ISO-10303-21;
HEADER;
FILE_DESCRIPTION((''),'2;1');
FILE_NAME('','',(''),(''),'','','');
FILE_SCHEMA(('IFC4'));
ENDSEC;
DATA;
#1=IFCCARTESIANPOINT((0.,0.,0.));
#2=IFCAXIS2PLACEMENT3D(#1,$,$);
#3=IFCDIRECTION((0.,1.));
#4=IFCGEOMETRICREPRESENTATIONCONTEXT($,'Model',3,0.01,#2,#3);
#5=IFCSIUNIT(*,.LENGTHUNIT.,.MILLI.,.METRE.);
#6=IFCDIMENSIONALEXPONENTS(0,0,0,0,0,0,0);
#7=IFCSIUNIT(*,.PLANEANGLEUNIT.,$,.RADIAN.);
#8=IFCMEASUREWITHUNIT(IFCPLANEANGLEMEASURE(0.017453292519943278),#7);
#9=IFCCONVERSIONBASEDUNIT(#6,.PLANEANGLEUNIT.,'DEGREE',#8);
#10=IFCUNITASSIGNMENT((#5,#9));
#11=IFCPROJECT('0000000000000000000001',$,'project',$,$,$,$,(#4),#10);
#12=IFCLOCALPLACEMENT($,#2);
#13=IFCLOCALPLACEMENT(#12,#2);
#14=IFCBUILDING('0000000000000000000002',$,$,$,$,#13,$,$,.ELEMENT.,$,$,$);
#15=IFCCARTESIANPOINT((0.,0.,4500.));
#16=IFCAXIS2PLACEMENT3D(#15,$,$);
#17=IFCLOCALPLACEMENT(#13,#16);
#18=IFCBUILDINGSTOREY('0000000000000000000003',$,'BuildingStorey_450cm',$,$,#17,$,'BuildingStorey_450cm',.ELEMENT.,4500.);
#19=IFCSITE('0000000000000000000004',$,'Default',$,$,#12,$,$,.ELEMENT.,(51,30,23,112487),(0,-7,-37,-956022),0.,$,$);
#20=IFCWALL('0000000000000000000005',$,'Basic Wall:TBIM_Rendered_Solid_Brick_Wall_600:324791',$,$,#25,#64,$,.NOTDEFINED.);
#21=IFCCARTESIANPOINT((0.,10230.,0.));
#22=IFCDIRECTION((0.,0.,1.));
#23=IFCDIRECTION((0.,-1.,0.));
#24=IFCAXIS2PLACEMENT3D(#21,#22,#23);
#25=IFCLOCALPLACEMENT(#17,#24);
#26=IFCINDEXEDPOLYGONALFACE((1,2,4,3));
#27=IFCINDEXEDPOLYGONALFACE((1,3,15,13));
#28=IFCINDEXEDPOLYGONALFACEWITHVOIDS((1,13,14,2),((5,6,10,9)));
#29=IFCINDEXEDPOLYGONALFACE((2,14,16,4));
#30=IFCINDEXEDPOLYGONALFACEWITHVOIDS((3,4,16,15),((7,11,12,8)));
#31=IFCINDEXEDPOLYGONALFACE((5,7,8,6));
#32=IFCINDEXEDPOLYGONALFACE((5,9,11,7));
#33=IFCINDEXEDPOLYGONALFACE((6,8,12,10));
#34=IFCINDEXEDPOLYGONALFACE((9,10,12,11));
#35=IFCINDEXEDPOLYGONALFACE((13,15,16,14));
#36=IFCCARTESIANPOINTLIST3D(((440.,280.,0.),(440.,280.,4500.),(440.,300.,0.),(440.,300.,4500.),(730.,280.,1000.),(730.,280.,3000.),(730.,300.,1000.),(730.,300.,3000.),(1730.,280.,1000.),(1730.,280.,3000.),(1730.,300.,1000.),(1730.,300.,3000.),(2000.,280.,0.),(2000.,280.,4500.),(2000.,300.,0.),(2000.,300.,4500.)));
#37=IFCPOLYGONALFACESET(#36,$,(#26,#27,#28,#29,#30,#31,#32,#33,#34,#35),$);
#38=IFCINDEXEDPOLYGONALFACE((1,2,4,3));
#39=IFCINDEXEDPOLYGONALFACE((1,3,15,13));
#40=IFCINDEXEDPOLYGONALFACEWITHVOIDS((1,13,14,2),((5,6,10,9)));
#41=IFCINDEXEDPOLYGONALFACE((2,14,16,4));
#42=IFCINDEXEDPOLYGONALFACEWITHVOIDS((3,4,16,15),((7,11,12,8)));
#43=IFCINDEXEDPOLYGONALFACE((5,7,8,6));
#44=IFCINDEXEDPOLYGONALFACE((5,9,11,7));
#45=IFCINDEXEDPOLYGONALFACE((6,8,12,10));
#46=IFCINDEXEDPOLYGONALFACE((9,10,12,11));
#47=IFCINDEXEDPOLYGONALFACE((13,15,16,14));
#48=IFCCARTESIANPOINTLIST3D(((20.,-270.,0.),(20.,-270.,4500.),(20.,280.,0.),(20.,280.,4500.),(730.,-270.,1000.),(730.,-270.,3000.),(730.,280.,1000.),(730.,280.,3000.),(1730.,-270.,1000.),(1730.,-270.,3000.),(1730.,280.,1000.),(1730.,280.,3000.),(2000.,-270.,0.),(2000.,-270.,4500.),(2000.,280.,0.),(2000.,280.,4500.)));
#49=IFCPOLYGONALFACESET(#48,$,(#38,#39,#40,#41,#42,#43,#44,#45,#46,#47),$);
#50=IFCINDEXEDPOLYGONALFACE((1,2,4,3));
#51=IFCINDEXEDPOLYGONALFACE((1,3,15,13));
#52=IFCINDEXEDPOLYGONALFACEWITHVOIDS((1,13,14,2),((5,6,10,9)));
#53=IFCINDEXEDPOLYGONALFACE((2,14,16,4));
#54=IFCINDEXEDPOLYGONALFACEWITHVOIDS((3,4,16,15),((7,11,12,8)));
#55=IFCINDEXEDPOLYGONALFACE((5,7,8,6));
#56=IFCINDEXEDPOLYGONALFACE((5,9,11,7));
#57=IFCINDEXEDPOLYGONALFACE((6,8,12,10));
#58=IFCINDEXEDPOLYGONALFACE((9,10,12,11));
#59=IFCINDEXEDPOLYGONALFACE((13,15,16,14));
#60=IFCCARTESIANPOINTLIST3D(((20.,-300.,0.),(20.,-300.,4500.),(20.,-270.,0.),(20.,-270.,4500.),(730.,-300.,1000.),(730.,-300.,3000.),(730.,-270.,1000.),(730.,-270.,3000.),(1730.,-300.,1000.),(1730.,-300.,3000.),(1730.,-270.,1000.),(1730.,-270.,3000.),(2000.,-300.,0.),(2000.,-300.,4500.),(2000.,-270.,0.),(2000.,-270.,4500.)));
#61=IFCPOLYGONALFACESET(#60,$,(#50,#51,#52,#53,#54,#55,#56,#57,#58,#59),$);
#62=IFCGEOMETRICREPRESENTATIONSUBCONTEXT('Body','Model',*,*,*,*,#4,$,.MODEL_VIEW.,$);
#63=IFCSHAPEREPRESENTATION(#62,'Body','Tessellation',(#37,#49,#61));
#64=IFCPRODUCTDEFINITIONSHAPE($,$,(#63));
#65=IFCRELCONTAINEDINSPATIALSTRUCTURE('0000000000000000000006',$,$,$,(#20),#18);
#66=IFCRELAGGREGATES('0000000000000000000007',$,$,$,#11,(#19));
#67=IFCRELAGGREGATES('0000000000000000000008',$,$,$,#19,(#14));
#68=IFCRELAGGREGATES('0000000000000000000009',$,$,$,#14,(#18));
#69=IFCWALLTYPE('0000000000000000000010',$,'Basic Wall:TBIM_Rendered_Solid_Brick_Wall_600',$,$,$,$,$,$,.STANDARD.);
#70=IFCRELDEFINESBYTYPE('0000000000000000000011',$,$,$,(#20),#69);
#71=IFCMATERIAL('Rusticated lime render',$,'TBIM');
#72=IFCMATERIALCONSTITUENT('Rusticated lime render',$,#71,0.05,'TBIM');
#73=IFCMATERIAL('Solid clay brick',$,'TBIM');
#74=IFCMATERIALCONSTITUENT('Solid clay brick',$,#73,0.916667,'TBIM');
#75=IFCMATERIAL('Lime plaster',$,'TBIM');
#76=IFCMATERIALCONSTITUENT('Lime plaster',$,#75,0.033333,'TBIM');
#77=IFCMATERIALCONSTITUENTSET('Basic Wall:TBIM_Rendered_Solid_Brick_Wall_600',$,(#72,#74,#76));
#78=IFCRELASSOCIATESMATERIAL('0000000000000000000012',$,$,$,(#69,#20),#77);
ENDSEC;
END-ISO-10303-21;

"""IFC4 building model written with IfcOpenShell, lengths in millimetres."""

from ifc_helpers import new_model, entity, si_unit, converted_unit, direction, frame, origin, place, context, subcontext, project, spatial, indexed_curve, outline, extrude, material, constituent, constituent_set, type_object, element, save


model = new_model("IFC4")

# Units and contexts
model_context = context("Model", 3, precision=0.01, world=origin(), true_north=direction((0.0, 1.0)))
body_context = subcontext(model_context, "Body", "Model", "MODEL_VIEW")
ifc_project = project(units=[si_unit("LENGTHUNIT", "METRE", prefix="MILLI"), converted_unit("PLANEANGLEUNIT", "DEGREE", entity("IfcPlaneAngleMeasure", 0.017453292519943278), si_unit("PLANEANGLEUNIT", "RADIAN"), dimensions=[0, 0, 0, 0, 0, 0, 0])], contexts=[model_context])

# Site, building, storey
site_placement = place(None, origin())
site = spatial("IfcSite", under=ifc_project, at=site_placement, Name="Default", CompositionType="ELEMENT", RefLatitude=(51, 30, 23, 112487), RefLongitude=(0, -7, -37, -956022), RefElevation=0.0)
building_placement = place(site_placement, origin())
building = spatial("IfcBuilding", under=site, at=building_placement, CompositionType="ELEMENT")
storey_placement = place(building_placement, frame((0.0, 0.0, 4500.0)))
storey = spatial("IfcBuildingStorey", under=building, at=storey_placement, Name="BuildingStorey_450cm", LongName="BuildingStorey_450cm", CompositionType="ELEMENT", Elevation=4500.0)

# Shared definitions
ifc_material_1 = material(Name="Lime plaster", Category="TBIM")

# Wall, opening
ifc_material_2 = material(Name="Rusticated lime render", Category="TBIM")
ifc_constituent_1 = constituent(ifc_material_2, Name="Rusticated lime render", Category="TBIM", fraction=0.05)
ifc_material_3 = material(Name="Solid clay brick", Category="TBIM")
ifc_constituent_2 = constituent(ifc_material_3, Name="Solid clay brick", Category="TBIM", fraction=0.916667)
ifc_constituent_3 = constituent(ifc_material_1, Name="Lime plaster", Category="TBIM", fraction=0.033333)
ifc_constituent_set_1 = constituent_set(constituents=[ifc_constituent_1, ifc_constituent_2, ifc_constituent_3], Name="Basic Wall:TBIM_Rendered_Solid_Brick_Wall_600")
wall_type_1 = type_object("IfcWallType", Name="Basic Wall:TBIM_Rendered_Solid_Brick_Wall_600", PredefinedType="STANDARD", material=ifc_constituent_set_1)
wall_1_placement = place(storey_placement, frame((0.0, 10230.0, 0.0), z_axis=(0.0, 0.0, 1.0), x_axis=(0.0, -1.0, 0.0)))
wall_1 = element("IfcWall", 1, at=wall_1_placement, inside=storey, type_object=wall_type_1, material=ifc_constituent_set_1, Name="Basic Wall:TBIM_Rendered_Solid_Brick_Wall_600:324791", PredefinedType="NOTDEFINED", context=body_context, shape_type="SweptSolid", body=[
    extrude(outline(indexed_curve([(-2250.0, -780.0), (2250.0, -780.0), (2250.0, 780.0), (-2250.0, 780.0), (-2250.0, -780.0)], self_intersect=False), holes=[indexed_curve([(-1250.0, -490.0), (-1250.0, 510.0), (750.0, 510.0), (750.0, -490.0), (-1250.0, -490.0)], self_intersect=False)]), frame((1220.0, 280.0, 2250.0), z_axis=(0.0, 1.0, 0.0), x_axis=(0.0, 0.0, 1.0)), (0.0, 0.0, 1.0), 20.0),
    extrude(outline(indexed_curve([(-2250.0, -990.0), (2250.0, -990.0), (2250.0, 990.0), (-2250.0, 990.0), (-2250.0, -990.0)], self_intersect=False), holes=[indexed_curve([(-1250.0, -280.0), (-1250.0, 720.0), (750.0, 720.0), (750.0, -280.0), (-1250.0, -280.0)], self_intersect=False)]), frame((1010.0, -270.0, 2250.0), z_axis=(0.0, 1.0, 0.0), x_axis=(0.0, 0.0, 1.0)), (0.0, 0.0, 1.0), 550.0),
    extrude(outline(indexed_curve([(-2250.0, -990.0), (2250.0, -990.0), (2250.0, 990.0), (-2250.0, 990.0), (-2250.0, -990.0)], self_intersect=False), holes=[indexed_curve([(750.0, -280.0), (-1250.0, -280.0), (-1250.0, 720.0), (750.0, 720.0), (750.0, -280.0)], self_intersect=False)]), frame((1010.0, -300.0, 2250.0), z_axis=(0.0, 1.0, 0.0), x_axis=(0.0, 0.0, 1.0)), (0.0, 0.0, 1.0), 30.0),
])
opening_1_placement = place(wall_1_placement, frame((730.0, -300.0, 1000.0)))
element("IfcOpeningElement", 2, at=opening_1_placement, cuts=wall_1, PredefinedType="OPENING", context=body_context, shape_type="SweptSolid", body=[
    extrude(outline(indexed_curve([(2000.0, 0.0), (2000.0, 1000.0), (0.0, 1000.0), (0.0, 0.0), (2000.0, 0.0)], self_intersect=False)), frame((0.0, 0.0, 0.0), z_axis=(0.0, 1.0, 0.0), x_axis=(0.0, 0.0, 1.0)), (0.0, 0.0, 1.0), 600.0),
])

save(model, "model.ifc")
